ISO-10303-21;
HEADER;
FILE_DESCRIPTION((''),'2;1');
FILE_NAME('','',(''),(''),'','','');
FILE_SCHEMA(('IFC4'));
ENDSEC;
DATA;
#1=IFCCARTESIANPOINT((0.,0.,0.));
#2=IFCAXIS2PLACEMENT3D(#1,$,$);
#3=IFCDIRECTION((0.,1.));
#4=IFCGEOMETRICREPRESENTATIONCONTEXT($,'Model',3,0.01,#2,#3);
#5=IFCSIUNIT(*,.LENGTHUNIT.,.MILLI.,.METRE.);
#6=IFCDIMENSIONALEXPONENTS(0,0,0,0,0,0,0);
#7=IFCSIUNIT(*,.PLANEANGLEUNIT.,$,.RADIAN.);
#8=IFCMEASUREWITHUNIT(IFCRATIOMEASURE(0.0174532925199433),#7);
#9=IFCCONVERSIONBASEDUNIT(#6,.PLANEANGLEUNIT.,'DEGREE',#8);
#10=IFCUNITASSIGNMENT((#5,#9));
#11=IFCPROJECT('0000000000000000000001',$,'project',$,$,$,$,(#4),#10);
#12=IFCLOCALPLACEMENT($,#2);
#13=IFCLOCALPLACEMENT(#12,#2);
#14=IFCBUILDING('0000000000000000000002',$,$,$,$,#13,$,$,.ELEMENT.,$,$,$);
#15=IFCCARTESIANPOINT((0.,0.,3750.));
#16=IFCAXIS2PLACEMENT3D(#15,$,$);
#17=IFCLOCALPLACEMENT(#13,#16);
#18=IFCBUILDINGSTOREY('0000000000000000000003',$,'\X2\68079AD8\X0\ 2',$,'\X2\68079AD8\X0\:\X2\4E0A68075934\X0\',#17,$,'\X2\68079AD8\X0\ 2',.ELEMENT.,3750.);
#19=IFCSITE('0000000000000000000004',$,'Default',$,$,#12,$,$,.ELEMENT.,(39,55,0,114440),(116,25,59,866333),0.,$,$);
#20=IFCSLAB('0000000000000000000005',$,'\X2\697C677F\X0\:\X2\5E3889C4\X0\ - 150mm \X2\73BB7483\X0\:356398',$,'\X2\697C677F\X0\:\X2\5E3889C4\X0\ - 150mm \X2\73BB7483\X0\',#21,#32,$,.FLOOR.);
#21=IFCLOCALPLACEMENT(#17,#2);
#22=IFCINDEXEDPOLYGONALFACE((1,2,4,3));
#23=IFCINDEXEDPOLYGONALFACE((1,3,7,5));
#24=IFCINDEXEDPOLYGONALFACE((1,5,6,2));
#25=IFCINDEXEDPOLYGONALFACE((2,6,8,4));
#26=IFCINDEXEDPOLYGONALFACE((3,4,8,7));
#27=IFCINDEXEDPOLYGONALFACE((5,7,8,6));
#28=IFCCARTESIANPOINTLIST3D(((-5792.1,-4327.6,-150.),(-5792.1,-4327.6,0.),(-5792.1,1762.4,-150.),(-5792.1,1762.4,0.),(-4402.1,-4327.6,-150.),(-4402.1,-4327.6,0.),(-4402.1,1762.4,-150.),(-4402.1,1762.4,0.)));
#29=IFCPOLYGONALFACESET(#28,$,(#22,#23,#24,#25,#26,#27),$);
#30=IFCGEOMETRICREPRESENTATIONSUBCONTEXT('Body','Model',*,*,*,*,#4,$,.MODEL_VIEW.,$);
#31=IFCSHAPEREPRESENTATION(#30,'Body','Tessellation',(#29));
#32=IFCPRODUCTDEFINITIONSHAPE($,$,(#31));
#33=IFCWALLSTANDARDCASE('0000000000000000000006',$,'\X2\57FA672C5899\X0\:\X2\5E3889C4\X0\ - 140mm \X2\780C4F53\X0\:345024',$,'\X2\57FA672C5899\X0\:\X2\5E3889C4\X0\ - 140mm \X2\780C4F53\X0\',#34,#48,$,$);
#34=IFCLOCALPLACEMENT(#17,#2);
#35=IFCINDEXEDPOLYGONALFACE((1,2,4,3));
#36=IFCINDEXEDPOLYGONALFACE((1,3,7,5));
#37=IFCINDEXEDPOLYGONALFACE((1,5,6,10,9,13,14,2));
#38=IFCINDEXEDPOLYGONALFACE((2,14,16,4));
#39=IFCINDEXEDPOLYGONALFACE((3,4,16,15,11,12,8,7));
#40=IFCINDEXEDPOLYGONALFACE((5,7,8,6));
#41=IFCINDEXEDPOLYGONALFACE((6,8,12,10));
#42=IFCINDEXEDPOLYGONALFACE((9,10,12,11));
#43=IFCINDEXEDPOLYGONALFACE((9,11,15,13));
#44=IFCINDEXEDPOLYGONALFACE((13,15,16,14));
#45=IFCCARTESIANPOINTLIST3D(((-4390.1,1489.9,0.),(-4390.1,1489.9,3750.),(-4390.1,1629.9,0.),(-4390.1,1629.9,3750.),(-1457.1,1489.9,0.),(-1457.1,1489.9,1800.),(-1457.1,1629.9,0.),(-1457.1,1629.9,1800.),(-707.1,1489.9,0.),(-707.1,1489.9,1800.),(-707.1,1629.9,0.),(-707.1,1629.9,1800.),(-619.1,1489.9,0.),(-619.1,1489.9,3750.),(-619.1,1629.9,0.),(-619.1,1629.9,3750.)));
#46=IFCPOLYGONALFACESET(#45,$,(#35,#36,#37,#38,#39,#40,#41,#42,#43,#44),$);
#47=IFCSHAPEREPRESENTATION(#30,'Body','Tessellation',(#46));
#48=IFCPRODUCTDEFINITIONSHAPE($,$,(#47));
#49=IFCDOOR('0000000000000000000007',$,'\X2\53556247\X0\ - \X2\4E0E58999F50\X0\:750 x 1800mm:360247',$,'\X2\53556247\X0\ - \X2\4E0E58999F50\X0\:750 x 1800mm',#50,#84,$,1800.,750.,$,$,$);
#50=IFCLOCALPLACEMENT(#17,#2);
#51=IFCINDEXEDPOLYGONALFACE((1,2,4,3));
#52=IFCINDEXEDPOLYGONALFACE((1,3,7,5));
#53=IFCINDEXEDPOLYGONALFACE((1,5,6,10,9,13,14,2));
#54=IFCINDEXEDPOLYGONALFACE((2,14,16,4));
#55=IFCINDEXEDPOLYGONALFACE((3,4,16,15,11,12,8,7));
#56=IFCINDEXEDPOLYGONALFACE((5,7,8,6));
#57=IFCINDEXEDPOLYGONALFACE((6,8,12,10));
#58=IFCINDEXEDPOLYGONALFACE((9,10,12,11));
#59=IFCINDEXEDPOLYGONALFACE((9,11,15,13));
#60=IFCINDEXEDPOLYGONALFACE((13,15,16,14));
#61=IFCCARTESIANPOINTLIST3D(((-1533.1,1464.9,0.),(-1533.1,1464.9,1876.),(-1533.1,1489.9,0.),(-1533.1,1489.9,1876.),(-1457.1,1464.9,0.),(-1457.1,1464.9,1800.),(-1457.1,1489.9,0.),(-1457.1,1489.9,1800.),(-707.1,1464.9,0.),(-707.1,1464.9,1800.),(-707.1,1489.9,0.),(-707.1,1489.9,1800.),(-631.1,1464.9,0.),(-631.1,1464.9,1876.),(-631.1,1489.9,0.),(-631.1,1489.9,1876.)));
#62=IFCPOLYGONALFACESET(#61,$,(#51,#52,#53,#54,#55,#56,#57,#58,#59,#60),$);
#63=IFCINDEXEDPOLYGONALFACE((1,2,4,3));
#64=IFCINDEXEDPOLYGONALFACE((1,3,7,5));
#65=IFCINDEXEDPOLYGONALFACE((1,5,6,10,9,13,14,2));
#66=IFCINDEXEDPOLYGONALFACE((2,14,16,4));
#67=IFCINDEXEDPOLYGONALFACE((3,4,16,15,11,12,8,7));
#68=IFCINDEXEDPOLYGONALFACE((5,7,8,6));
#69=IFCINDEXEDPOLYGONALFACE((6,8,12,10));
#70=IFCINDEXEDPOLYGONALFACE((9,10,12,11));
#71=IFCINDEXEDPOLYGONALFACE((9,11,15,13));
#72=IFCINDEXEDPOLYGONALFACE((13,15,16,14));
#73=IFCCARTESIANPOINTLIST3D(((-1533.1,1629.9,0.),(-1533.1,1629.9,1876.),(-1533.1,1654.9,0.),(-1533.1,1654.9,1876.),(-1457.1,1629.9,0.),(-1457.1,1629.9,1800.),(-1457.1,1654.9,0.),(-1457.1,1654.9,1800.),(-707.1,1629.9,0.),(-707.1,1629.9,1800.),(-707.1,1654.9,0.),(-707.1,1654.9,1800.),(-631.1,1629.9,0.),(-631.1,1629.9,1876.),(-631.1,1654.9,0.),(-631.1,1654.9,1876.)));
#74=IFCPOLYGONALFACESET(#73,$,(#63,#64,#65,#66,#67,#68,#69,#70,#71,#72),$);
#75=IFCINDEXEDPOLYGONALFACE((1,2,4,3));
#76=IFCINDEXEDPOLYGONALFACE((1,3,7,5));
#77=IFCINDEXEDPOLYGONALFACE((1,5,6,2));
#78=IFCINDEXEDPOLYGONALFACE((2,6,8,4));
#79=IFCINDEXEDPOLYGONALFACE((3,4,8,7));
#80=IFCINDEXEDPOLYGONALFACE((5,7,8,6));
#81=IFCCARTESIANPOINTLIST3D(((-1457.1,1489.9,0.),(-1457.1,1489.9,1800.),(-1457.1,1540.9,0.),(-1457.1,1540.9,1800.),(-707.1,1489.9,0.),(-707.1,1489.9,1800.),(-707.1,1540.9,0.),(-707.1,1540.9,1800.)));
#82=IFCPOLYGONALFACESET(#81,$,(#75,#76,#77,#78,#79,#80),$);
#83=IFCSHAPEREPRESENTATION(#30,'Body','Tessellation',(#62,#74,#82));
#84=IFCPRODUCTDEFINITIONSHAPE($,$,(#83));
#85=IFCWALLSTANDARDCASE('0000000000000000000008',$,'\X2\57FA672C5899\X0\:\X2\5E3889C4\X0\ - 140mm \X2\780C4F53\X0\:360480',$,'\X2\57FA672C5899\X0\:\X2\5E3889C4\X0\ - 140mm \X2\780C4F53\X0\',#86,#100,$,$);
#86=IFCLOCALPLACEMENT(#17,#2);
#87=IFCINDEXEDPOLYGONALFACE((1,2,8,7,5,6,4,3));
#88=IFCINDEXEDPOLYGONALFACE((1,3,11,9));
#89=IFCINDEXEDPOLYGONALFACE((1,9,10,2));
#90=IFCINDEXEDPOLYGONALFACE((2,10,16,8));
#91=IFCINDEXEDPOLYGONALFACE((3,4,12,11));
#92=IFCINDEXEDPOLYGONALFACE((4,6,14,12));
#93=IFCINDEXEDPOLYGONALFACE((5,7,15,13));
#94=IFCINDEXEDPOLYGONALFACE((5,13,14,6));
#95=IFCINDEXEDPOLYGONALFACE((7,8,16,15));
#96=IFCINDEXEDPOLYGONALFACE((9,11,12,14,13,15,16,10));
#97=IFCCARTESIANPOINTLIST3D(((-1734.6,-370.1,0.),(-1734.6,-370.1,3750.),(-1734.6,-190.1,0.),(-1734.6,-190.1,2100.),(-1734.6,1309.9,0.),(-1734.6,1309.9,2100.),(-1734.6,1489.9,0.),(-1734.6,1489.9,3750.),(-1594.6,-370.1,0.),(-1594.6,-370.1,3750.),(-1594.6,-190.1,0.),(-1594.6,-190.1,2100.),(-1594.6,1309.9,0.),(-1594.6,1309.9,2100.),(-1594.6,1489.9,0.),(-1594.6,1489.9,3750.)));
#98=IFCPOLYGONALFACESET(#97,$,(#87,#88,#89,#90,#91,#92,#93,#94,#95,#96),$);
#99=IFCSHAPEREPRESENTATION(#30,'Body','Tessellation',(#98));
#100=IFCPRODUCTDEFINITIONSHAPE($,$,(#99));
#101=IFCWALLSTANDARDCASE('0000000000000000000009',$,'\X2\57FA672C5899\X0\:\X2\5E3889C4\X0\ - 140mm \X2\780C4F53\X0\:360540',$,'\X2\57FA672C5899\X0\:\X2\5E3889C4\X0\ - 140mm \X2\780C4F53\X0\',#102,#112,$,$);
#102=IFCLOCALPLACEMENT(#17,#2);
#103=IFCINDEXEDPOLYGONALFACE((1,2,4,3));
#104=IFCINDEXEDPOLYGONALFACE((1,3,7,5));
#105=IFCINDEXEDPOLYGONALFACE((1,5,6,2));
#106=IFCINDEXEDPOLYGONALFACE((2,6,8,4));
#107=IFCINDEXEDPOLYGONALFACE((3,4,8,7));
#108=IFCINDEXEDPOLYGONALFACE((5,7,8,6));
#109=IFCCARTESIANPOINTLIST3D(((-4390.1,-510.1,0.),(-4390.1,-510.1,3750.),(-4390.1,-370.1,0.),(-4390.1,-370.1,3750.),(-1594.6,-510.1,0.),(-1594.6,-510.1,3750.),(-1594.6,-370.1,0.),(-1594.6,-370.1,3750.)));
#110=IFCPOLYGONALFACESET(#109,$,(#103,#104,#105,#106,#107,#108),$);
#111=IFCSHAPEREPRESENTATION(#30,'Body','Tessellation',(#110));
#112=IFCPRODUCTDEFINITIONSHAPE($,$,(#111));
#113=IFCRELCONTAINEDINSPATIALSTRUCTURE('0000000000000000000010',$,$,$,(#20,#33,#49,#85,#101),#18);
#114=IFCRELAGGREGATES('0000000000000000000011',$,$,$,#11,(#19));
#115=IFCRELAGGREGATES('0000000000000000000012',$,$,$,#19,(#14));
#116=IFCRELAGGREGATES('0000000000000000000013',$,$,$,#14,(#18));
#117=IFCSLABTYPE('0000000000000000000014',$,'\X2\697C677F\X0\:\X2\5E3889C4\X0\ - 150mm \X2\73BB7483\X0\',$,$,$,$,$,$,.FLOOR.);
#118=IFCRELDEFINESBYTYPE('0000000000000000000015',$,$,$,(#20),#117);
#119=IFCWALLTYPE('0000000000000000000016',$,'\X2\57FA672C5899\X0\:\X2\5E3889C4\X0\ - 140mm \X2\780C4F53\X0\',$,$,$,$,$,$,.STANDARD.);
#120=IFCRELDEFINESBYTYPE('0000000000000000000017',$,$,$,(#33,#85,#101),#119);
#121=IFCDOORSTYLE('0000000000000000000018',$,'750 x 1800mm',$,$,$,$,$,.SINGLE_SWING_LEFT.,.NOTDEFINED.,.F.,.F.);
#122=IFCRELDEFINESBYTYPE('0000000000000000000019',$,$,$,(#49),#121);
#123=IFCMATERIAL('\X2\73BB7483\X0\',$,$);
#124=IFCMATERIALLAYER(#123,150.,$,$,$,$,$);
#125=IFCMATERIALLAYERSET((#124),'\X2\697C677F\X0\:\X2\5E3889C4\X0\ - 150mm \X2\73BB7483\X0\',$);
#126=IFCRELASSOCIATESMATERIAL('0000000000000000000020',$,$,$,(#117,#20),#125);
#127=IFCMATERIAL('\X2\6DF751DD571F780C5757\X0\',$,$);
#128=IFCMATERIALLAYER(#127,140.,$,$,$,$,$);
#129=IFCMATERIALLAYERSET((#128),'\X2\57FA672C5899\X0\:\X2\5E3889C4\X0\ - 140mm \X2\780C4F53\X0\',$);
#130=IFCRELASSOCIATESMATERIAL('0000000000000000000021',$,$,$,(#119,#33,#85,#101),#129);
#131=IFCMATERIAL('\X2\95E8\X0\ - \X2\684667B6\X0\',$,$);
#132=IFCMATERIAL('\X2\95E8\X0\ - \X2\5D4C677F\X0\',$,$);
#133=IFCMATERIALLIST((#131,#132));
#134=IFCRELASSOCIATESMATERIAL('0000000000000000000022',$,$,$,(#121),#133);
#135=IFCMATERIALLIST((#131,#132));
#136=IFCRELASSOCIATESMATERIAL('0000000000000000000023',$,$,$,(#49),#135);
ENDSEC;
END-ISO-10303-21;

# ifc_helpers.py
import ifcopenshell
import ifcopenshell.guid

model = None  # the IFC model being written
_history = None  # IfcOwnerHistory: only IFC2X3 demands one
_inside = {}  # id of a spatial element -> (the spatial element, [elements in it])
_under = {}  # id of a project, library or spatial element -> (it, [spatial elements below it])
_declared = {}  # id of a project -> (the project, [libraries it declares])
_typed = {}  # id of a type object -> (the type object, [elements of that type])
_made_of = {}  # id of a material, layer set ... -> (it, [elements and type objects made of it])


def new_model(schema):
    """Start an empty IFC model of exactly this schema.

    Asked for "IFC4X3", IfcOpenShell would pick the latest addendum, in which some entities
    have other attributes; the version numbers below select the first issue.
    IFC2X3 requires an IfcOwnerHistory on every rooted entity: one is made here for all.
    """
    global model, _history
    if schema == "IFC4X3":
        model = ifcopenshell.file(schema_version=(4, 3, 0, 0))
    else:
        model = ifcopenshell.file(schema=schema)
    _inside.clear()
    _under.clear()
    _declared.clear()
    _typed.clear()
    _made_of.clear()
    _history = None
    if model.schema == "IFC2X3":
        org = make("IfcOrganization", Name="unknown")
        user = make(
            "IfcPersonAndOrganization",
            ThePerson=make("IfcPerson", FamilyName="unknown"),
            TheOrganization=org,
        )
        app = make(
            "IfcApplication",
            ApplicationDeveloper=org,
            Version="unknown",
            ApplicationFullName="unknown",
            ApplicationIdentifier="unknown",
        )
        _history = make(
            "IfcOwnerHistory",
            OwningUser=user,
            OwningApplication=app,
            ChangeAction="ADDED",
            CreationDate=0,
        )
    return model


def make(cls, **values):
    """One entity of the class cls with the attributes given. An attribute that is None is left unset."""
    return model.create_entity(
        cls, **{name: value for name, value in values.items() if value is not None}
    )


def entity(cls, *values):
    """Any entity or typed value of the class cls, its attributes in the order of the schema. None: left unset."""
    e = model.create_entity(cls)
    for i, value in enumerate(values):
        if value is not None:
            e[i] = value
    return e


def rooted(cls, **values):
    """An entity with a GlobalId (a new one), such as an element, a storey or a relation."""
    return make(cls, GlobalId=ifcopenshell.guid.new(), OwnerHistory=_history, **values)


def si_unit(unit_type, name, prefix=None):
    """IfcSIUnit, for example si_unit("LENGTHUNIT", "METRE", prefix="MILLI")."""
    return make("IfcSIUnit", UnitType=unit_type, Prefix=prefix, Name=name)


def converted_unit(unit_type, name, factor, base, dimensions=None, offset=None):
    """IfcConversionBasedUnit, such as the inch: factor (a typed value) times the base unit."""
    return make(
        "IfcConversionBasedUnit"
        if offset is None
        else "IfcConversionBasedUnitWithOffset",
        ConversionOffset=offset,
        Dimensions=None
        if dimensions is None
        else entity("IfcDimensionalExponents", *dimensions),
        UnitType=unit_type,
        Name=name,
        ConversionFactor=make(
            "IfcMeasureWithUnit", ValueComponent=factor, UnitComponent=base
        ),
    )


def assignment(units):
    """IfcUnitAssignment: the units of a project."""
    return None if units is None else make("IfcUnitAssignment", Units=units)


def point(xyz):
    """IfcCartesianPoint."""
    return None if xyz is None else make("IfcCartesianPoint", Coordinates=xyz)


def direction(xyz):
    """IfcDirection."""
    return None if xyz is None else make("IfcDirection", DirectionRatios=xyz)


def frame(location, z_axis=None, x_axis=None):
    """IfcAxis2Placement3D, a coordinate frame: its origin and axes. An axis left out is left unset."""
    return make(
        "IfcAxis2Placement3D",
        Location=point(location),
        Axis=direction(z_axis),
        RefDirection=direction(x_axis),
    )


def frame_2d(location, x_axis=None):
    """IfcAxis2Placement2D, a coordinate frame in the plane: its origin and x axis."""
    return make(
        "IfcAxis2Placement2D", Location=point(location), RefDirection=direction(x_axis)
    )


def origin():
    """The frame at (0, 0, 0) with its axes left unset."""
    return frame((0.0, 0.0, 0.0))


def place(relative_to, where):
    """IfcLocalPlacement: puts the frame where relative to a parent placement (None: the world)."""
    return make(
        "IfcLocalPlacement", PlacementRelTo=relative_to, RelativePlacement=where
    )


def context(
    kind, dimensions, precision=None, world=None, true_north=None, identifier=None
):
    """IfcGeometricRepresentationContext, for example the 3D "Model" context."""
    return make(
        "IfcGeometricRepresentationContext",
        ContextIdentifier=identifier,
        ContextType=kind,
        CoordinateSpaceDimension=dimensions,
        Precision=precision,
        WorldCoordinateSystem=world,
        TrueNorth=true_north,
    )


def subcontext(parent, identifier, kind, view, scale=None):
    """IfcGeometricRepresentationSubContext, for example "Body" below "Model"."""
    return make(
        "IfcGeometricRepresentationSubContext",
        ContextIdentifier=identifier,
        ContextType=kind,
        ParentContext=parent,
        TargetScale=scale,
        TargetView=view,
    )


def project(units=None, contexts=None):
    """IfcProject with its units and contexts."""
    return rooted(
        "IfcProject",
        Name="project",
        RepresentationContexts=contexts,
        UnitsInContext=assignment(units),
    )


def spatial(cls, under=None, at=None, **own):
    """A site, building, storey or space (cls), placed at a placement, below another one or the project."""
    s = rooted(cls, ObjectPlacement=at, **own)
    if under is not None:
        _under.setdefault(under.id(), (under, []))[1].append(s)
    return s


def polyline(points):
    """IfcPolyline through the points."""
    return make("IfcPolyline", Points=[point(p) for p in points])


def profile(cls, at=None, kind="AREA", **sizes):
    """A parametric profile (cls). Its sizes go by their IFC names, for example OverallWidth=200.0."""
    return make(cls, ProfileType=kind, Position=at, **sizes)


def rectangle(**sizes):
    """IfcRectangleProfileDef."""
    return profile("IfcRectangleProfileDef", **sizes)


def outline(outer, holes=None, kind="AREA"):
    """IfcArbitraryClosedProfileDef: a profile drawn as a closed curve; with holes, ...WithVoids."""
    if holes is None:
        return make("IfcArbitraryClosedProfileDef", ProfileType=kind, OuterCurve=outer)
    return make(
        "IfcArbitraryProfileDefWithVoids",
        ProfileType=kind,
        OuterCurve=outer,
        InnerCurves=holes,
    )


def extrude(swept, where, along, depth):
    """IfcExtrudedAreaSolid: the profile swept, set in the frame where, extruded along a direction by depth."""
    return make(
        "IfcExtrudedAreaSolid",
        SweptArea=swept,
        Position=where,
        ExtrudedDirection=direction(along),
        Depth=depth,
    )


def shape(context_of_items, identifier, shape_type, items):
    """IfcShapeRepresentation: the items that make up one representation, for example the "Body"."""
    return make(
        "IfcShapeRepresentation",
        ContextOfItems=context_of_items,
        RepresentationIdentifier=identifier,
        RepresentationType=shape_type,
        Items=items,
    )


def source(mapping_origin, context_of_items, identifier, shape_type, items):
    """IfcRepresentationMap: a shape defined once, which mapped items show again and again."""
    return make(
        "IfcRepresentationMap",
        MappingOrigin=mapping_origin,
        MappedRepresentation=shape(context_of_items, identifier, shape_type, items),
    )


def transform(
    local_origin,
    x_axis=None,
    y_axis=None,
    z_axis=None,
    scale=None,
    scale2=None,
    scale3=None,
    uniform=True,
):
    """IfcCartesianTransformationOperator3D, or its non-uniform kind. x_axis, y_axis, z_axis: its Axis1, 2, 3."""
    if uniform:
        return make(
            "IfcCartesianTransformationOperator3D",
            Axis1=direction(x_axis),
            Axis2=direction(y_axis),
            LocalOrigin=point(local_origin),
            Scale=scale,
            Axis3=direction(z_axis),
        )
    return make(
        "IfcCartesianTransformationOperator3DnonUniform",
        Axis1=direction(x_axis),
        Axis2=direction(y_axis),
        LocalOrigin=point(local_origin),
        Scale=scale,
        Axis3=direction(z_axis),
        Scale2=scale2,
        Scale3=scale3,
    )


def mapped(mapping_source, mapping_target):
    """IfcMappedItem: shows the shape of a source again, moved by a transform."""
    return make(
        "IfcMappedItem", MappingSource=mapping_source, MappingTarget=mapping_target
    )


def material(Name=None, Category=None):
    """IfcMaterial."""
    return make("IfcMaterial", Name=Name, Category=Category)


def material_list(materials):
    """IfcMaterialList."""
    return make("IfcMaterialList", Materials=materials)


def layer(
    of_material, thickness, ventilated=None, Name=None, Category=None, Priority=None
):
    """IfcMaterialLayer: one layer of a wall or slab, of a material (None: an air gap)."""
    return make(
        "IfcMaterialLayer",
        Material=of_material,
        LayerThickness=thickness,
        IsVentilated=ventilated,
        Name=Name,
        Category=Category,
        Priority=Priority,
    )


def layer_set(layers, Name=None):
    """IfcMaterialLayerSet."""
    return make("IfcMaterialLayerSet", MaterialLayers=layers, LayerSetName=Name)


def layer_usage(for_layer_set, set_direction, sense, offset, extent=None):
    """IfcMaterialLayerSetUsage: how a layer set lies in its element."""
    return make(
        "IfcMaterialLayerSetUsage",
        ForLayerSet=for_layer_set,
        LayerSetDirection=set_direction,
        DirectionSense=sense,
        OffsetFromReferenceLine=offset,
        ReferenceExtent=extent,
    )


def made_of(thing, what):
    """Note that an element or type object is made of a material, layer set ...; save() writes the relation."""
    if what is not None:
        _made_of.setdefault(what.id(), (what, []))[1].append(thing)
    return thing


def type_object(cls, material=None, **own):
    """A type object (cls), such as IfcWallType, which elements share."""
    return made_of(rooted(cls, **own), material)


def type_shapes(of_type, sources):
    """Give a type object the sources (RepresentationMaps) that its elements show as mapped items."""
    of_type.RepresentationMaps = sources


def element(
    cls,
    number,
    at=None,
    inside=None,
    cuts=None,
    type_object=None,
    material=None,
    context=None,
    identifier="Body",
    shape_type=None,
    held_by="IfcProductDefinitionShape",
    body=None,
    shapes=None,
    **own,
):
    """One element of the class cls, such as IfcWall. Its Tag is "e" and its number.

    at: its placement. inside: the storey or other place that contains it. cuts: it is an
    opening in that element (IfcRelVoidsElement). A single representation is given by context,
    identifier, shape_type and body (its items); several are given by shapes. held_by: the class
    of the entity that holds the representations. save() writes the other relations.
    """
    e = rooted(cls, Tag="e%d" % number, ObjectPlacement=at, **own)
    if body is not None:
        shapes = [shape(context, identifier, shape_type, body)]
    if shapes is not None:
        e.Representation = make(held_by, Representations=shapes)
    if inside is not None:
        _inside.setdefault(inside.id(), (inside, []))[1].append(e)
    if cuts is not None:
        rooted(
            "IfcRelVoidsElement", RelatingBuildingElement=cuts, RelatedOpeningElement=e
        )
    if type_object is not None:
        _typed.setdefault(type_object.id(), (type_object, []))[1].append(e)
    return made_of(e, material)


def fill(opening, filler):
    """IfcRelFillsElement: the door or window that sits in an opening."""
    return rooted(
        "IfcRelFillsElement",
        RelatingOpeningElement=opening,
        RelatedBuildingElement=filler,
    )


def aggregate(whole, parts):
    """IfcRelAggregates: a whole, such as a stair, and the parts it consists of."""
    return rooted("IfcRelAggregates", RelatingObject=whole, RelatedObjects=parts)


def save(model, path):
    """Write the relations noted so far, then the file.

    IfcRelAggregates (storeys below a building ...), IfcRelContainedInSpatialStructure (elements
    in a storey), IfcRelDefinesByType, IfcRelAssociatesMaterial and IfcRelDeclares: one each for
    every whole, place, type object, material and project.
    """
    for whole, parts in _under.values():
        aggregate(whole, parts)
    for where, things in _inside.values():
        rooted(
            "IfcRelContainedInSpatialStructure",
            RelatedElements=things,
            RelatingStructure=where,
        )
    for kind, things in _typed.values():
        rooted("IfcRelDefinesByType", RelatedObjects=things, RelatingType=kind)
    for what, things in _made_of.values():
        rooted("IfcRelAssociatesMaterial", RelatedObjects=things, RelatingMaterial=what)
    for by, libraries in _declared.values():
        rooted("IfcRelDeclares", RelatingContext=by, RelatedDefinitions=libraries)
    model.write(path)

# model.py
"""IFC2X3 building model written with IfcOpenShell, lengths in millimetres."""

from ifc_helpers import new_model, entity, si_unit, converted_unit, direction, frame, frame_2d, origin, place, context, subcontext, project, spatial, polyline, rectangle, outline, extrude, source, transform, mapped, material, material_list, layer, layer_set, layer_usage, type_object, type_shapes, element, fill, save


model = new_model("IFC2X3")

# Units and contexts
model_context = context("Model", 3, precision=0.01, world=origin(), true_north=direction((0.0, 1.0)))
body_context = subcontext(model_context, "Body", "Model", "MODEL_VIEW")
ifc_project = project(units=[si_unit("LENGTHUNIT", "METRE", prefix="MILLI"), converted_unit("PLANEANGLEUNIT", "DEGREE", entity("IfcRatioMeasure", 0.0174532925199433), si_unit("PLANEANGLEUNIT", "RADIAN"), dimensions=[0, 0, 0, 0, 0, 0, 0])], contexts=[model_context])

# Site, building, storey
site_placement = place(None, origin())
site = spatial("IfcSite", under=ifc_project, at=site_placement, Name="Default", CompositionType="ELEMENT", RefLatitude=(39, 55, 0, 114440), RefLongitude=(116, 25, 59, 866333), RefElevation=0.0)
building_placement = place(site_placement, origin())
building = spatial("IfcBuilding", under=site, at=building_placement, CompositionType="ELEMENT")
storey_placement = place(building_placement, frame((0.0, 0.0, 3750.0)))
storey = spatial("IfcBuildingStorey", under=building, at=storey_placement, Name="标高 2", ObjectType="标高:上标头", LongName="标高 2", CompositionType="ELEMENT", Elevation=3750.0)

# Slab
ifc_material_1 = material(Name="玻璃")
ifc_layer_1 = layer(ifc_material_1, 150.0)
ifc_layer_set_1 = layer_set([ifc_layer_1], Name="楼板:常规 - 150mm 玻璃")
ifc_layer_usage_1 = layer_usage(ifc_layer_set_1, "AXIS3", "POSITIVE", 0.0)
slab_type_1 = type_object("IfcSlabType", Name="楼板:常规 - 150mm 玻璃", PredefinedType="FLOOR", material=ifc_layer_set_1)
slab_1_placement = place(storey_placement, origin())
element("IfcSlab", 1, at=slab_1_placement, inside=storey, type_object=slab_type_1, material=ifc_layer_usage_1, Name="楼板:常规 - 150mm 玻璃:356398", ObjectType="楼板:常规 - 150mm 玻璃", PredefinedType="FLOOR", context=body_context, shape_type="SweptSolid", body=[
    extrude(rectangle(XDim=6090.0, YDim=1390.0, at=frame_2d((0.0, 0.0), x_axis=(1.0, 0.0))), frame((-5097.1, -1282.6, 0.0), z_axis=(0.0, 0.0, -1.0), x_axis=(0.0, 1.0, 0.0)), (0.0, 0.0, 1.0), 150.0),
])

# Wall, opening, door
ifc_material_2 = material(Name="混凝土砌块")
ifc_layer_2 = layer(ifc_material_2, 140.0)
ifc_layer_set_2 = layer_set([ifc_layer_2], Name="基本墙:常规 - 140mm 砌体")
ifc_layer_usage_2 = layer_usage(ifc_layer_set_2, "AXIS2", "NEGATIVE", 70.0)
wall_type = type_object("IfcWallType", Name="基本墙:常规 - 140mm 砌体", PredefinedType="STANDARD", material=ifc_layer_set_2)
wall_1_placement = place(storey_placement, frame((-4390.1, 1559.9, 0.0)))
wall_1 = element("IfcWallStandardCase", 2, at=wall_1_placement, inside=storey, type_object=wall_type, material=ifc_layer_usage_2, Name="基本墙:常规 - 140mm 砌体:345024", ObjectType="基本墙:常规 - 140mm 砌体", context=body_context, shape_type="SweptSolid", body=[
    extrude(rectangle(XDim=3771.0, YDim=140.0, at=frame_2d((1885.5, 0.0), x_axis=(-1.0, 0.0))), origin(), (0.0, 0.0, 1.0), 3750.0),
])
opening_1_placement = place(wall_1_placement, frame((3683.0, 70.0, 0.0)))
opening_1 = element("IfcOpeningElement", 3, at=opening_1_placement, cuts=wall_1, ObjectType="Opening", context=body_context, shape_type="SweptSolid", body=[
    extrude(rectangle(XDim=750.0, YDim=1800.0, at=frame_2d((900.0, 375.0), x_axis=(0.0, -1.0))), frame((0.0, 0.0, 0.0), z_axis=(0.0, -1.0, 0.0), x_axis=(0.0, 0.0, 1.0)), (0.0, 0.0, 1.0), 140.0),
])
ifc_material_3 = material(Name="门 - 框架")
ifc_material_4 = material(Name="门 - 嵌板")
ifc_material_list_1 = material_list([ifc_material_3, ifc_material_4])
ifc_material_list_2 = material_list([ifc_material_3, ifc_material_4])
door_style = type_object("IfcDoorStyle", Name="750 x 1800mm", ConstructionType="NOTDEFINED", OperationType="SINGLE_SWING_LEFT", ParameterTakesPrecedence=False, Sizeable=False, material=ifc_material_list_2)
shared_shape = source(origin(), body_context, "Body", "SweptSolid", [
    extrude(outline(polyline([(-451.0, -957.0), (451.0, -957.0), (451.0, 919.0), (375.0, 919.0), (375.0, -881.0), (-375.0, -881.0), (-375.0, 919.0), (-451.0, 919.0), (-451.0, -957.0)])), frame((375.0, 165.0, 919.0), z_axis=(0.0, -1.0, 0.0), x_axis=(-1.0, 0.0, 0.0)), (0.0, 0.0, 1.0), 25.0),
    extrude(outline(polyline([(-957.0, -451.0), (919.0, -451.0), (919.0, -375.0), (-881.0, -375.0), (-881.0, 375.0), (919.0, 375.0), (919.0, 451.0), (-957.0, 451.0), (-957.0, -451.0)])), frame((375.0, 0.0, 919.0), z_axis=(0.0, -1.0, 0.0), x_axis=(0.0, 0.0, -1.0)), (0.0, 0.0, 1.0), 25.0),
    extrude(rectangle(XDim=750.0, YDim=51.0, at=frame_2d((0.0, 0.0), x_axis=(1.0, 0.0))), frame((375.0, 114.5, 0.0)), (0.0, 0.0, 1.0), 1800.0),
])
type_shapes(door_style, [shared_shape])
door_placement = place(opening_1_placement, frame((0.0, 0.0, 0.0), z_axis=(0.0, 0.0, 1.0), x_axis=(-1.0, 0.0, 0.0)))
door = element("IfcDoor", 4, at=door_placement, inside=storey, type_object=door_style, material=ifc_material_list_1, Name="单扇 - 与墙齐:750 x 1800mm:360247", ObjectType="单扇 - 与墙齐:750 x 1800mm", OverallHeight=1800.0, OverallWidth=750.0, context=body_context, shape_type="MappedRepresentation", body=[
    mapped(shared_shape, transform((0.0, 0.0, 0.0), scale=1.0)),
])
fill(opening_1, door)

# Wall, opening
ifc_layer_usage_3 = layer_usage(ifc_layer_set_2, "AXIS2", "NEGATIVE", 70.0)
wall_2_placement = place(storey_placement, frame((-1664.6, 1489.9, 0.0), z_axis=(0.0, 0.0, 1.0), x_axis=(0.0, -1.0, 0.0)))
wall_2 = element("IfcWallStandardCase", 5, at=wall_2_placement, inside=storey, type_object=wall_type, material=ifc_layer_usage_3, Name="基本墙:常规 - 140mm 砌体:360480", ObjectType="基本墙:常规 - 140mm 砌体", context=body_context, shape_type="SweptSolid", body=[
    extrude(rectangle(XDim=1860.0, YDim=140.0, at=frame_2d((930.0, 0.0), x_axis=(-1.0, 0.0))), origin(), (0.0, 0.0, 1.0), 3750.0),
])
opening_2_placement = place(wall_2_placement, frame((180.0, -70.0, 0.0)))
element("IfcOpeningElement", 6, at=opening_2_placement, cuts=wall_2, ObjectType="Opening", context=body_context, shape_type="SweptSolid", body=[
    extrude(rectangle(XDim=2100.0, YDim=1500.0, at=frame_2d((1050.0, 750.0), x_axis=(1.0, 0.0))), frame((0.0, 0.0, 0.0), z_axis=(0.0, 1.0, 0.0), x_axis=(0.0, 0.0, 1.0)), (0.0, 0.0, 1.0), 140.0),
])

# Wall
ifc_layer_usage_4 = layer_usage(ifc_layer_set_2, "AXIS2", "NEGATIVE", 70.0)
wall_3_placement = place(storey_placement, frame((-1594.6, -440.1, 0.0), z_axis=(0.0, 0.0, 1.0), x_axis=(-1.0, 0.0, 0.0)))
element("IfcWallStandardCase", 7, at=wall_3_placement, inside=storey, type_object=wall_type, material=ifc_layer_usage_4, Name="基本墙:常规 - 140mm 砌体:360540", ObjectType="基本墙:常规 - 140mm 砌体", context=body_context, shape_type="SweptSolid", body=[
    extrude(rectangle(XDim=2795.5, YDim=140.0, at=frame_2d((1397.8, 0.0), x_axis=(-1.0, 0.0))), origin(), (0.0, 0.0, 1.0), 3750.0),
])

save(model, "model.ifc")
